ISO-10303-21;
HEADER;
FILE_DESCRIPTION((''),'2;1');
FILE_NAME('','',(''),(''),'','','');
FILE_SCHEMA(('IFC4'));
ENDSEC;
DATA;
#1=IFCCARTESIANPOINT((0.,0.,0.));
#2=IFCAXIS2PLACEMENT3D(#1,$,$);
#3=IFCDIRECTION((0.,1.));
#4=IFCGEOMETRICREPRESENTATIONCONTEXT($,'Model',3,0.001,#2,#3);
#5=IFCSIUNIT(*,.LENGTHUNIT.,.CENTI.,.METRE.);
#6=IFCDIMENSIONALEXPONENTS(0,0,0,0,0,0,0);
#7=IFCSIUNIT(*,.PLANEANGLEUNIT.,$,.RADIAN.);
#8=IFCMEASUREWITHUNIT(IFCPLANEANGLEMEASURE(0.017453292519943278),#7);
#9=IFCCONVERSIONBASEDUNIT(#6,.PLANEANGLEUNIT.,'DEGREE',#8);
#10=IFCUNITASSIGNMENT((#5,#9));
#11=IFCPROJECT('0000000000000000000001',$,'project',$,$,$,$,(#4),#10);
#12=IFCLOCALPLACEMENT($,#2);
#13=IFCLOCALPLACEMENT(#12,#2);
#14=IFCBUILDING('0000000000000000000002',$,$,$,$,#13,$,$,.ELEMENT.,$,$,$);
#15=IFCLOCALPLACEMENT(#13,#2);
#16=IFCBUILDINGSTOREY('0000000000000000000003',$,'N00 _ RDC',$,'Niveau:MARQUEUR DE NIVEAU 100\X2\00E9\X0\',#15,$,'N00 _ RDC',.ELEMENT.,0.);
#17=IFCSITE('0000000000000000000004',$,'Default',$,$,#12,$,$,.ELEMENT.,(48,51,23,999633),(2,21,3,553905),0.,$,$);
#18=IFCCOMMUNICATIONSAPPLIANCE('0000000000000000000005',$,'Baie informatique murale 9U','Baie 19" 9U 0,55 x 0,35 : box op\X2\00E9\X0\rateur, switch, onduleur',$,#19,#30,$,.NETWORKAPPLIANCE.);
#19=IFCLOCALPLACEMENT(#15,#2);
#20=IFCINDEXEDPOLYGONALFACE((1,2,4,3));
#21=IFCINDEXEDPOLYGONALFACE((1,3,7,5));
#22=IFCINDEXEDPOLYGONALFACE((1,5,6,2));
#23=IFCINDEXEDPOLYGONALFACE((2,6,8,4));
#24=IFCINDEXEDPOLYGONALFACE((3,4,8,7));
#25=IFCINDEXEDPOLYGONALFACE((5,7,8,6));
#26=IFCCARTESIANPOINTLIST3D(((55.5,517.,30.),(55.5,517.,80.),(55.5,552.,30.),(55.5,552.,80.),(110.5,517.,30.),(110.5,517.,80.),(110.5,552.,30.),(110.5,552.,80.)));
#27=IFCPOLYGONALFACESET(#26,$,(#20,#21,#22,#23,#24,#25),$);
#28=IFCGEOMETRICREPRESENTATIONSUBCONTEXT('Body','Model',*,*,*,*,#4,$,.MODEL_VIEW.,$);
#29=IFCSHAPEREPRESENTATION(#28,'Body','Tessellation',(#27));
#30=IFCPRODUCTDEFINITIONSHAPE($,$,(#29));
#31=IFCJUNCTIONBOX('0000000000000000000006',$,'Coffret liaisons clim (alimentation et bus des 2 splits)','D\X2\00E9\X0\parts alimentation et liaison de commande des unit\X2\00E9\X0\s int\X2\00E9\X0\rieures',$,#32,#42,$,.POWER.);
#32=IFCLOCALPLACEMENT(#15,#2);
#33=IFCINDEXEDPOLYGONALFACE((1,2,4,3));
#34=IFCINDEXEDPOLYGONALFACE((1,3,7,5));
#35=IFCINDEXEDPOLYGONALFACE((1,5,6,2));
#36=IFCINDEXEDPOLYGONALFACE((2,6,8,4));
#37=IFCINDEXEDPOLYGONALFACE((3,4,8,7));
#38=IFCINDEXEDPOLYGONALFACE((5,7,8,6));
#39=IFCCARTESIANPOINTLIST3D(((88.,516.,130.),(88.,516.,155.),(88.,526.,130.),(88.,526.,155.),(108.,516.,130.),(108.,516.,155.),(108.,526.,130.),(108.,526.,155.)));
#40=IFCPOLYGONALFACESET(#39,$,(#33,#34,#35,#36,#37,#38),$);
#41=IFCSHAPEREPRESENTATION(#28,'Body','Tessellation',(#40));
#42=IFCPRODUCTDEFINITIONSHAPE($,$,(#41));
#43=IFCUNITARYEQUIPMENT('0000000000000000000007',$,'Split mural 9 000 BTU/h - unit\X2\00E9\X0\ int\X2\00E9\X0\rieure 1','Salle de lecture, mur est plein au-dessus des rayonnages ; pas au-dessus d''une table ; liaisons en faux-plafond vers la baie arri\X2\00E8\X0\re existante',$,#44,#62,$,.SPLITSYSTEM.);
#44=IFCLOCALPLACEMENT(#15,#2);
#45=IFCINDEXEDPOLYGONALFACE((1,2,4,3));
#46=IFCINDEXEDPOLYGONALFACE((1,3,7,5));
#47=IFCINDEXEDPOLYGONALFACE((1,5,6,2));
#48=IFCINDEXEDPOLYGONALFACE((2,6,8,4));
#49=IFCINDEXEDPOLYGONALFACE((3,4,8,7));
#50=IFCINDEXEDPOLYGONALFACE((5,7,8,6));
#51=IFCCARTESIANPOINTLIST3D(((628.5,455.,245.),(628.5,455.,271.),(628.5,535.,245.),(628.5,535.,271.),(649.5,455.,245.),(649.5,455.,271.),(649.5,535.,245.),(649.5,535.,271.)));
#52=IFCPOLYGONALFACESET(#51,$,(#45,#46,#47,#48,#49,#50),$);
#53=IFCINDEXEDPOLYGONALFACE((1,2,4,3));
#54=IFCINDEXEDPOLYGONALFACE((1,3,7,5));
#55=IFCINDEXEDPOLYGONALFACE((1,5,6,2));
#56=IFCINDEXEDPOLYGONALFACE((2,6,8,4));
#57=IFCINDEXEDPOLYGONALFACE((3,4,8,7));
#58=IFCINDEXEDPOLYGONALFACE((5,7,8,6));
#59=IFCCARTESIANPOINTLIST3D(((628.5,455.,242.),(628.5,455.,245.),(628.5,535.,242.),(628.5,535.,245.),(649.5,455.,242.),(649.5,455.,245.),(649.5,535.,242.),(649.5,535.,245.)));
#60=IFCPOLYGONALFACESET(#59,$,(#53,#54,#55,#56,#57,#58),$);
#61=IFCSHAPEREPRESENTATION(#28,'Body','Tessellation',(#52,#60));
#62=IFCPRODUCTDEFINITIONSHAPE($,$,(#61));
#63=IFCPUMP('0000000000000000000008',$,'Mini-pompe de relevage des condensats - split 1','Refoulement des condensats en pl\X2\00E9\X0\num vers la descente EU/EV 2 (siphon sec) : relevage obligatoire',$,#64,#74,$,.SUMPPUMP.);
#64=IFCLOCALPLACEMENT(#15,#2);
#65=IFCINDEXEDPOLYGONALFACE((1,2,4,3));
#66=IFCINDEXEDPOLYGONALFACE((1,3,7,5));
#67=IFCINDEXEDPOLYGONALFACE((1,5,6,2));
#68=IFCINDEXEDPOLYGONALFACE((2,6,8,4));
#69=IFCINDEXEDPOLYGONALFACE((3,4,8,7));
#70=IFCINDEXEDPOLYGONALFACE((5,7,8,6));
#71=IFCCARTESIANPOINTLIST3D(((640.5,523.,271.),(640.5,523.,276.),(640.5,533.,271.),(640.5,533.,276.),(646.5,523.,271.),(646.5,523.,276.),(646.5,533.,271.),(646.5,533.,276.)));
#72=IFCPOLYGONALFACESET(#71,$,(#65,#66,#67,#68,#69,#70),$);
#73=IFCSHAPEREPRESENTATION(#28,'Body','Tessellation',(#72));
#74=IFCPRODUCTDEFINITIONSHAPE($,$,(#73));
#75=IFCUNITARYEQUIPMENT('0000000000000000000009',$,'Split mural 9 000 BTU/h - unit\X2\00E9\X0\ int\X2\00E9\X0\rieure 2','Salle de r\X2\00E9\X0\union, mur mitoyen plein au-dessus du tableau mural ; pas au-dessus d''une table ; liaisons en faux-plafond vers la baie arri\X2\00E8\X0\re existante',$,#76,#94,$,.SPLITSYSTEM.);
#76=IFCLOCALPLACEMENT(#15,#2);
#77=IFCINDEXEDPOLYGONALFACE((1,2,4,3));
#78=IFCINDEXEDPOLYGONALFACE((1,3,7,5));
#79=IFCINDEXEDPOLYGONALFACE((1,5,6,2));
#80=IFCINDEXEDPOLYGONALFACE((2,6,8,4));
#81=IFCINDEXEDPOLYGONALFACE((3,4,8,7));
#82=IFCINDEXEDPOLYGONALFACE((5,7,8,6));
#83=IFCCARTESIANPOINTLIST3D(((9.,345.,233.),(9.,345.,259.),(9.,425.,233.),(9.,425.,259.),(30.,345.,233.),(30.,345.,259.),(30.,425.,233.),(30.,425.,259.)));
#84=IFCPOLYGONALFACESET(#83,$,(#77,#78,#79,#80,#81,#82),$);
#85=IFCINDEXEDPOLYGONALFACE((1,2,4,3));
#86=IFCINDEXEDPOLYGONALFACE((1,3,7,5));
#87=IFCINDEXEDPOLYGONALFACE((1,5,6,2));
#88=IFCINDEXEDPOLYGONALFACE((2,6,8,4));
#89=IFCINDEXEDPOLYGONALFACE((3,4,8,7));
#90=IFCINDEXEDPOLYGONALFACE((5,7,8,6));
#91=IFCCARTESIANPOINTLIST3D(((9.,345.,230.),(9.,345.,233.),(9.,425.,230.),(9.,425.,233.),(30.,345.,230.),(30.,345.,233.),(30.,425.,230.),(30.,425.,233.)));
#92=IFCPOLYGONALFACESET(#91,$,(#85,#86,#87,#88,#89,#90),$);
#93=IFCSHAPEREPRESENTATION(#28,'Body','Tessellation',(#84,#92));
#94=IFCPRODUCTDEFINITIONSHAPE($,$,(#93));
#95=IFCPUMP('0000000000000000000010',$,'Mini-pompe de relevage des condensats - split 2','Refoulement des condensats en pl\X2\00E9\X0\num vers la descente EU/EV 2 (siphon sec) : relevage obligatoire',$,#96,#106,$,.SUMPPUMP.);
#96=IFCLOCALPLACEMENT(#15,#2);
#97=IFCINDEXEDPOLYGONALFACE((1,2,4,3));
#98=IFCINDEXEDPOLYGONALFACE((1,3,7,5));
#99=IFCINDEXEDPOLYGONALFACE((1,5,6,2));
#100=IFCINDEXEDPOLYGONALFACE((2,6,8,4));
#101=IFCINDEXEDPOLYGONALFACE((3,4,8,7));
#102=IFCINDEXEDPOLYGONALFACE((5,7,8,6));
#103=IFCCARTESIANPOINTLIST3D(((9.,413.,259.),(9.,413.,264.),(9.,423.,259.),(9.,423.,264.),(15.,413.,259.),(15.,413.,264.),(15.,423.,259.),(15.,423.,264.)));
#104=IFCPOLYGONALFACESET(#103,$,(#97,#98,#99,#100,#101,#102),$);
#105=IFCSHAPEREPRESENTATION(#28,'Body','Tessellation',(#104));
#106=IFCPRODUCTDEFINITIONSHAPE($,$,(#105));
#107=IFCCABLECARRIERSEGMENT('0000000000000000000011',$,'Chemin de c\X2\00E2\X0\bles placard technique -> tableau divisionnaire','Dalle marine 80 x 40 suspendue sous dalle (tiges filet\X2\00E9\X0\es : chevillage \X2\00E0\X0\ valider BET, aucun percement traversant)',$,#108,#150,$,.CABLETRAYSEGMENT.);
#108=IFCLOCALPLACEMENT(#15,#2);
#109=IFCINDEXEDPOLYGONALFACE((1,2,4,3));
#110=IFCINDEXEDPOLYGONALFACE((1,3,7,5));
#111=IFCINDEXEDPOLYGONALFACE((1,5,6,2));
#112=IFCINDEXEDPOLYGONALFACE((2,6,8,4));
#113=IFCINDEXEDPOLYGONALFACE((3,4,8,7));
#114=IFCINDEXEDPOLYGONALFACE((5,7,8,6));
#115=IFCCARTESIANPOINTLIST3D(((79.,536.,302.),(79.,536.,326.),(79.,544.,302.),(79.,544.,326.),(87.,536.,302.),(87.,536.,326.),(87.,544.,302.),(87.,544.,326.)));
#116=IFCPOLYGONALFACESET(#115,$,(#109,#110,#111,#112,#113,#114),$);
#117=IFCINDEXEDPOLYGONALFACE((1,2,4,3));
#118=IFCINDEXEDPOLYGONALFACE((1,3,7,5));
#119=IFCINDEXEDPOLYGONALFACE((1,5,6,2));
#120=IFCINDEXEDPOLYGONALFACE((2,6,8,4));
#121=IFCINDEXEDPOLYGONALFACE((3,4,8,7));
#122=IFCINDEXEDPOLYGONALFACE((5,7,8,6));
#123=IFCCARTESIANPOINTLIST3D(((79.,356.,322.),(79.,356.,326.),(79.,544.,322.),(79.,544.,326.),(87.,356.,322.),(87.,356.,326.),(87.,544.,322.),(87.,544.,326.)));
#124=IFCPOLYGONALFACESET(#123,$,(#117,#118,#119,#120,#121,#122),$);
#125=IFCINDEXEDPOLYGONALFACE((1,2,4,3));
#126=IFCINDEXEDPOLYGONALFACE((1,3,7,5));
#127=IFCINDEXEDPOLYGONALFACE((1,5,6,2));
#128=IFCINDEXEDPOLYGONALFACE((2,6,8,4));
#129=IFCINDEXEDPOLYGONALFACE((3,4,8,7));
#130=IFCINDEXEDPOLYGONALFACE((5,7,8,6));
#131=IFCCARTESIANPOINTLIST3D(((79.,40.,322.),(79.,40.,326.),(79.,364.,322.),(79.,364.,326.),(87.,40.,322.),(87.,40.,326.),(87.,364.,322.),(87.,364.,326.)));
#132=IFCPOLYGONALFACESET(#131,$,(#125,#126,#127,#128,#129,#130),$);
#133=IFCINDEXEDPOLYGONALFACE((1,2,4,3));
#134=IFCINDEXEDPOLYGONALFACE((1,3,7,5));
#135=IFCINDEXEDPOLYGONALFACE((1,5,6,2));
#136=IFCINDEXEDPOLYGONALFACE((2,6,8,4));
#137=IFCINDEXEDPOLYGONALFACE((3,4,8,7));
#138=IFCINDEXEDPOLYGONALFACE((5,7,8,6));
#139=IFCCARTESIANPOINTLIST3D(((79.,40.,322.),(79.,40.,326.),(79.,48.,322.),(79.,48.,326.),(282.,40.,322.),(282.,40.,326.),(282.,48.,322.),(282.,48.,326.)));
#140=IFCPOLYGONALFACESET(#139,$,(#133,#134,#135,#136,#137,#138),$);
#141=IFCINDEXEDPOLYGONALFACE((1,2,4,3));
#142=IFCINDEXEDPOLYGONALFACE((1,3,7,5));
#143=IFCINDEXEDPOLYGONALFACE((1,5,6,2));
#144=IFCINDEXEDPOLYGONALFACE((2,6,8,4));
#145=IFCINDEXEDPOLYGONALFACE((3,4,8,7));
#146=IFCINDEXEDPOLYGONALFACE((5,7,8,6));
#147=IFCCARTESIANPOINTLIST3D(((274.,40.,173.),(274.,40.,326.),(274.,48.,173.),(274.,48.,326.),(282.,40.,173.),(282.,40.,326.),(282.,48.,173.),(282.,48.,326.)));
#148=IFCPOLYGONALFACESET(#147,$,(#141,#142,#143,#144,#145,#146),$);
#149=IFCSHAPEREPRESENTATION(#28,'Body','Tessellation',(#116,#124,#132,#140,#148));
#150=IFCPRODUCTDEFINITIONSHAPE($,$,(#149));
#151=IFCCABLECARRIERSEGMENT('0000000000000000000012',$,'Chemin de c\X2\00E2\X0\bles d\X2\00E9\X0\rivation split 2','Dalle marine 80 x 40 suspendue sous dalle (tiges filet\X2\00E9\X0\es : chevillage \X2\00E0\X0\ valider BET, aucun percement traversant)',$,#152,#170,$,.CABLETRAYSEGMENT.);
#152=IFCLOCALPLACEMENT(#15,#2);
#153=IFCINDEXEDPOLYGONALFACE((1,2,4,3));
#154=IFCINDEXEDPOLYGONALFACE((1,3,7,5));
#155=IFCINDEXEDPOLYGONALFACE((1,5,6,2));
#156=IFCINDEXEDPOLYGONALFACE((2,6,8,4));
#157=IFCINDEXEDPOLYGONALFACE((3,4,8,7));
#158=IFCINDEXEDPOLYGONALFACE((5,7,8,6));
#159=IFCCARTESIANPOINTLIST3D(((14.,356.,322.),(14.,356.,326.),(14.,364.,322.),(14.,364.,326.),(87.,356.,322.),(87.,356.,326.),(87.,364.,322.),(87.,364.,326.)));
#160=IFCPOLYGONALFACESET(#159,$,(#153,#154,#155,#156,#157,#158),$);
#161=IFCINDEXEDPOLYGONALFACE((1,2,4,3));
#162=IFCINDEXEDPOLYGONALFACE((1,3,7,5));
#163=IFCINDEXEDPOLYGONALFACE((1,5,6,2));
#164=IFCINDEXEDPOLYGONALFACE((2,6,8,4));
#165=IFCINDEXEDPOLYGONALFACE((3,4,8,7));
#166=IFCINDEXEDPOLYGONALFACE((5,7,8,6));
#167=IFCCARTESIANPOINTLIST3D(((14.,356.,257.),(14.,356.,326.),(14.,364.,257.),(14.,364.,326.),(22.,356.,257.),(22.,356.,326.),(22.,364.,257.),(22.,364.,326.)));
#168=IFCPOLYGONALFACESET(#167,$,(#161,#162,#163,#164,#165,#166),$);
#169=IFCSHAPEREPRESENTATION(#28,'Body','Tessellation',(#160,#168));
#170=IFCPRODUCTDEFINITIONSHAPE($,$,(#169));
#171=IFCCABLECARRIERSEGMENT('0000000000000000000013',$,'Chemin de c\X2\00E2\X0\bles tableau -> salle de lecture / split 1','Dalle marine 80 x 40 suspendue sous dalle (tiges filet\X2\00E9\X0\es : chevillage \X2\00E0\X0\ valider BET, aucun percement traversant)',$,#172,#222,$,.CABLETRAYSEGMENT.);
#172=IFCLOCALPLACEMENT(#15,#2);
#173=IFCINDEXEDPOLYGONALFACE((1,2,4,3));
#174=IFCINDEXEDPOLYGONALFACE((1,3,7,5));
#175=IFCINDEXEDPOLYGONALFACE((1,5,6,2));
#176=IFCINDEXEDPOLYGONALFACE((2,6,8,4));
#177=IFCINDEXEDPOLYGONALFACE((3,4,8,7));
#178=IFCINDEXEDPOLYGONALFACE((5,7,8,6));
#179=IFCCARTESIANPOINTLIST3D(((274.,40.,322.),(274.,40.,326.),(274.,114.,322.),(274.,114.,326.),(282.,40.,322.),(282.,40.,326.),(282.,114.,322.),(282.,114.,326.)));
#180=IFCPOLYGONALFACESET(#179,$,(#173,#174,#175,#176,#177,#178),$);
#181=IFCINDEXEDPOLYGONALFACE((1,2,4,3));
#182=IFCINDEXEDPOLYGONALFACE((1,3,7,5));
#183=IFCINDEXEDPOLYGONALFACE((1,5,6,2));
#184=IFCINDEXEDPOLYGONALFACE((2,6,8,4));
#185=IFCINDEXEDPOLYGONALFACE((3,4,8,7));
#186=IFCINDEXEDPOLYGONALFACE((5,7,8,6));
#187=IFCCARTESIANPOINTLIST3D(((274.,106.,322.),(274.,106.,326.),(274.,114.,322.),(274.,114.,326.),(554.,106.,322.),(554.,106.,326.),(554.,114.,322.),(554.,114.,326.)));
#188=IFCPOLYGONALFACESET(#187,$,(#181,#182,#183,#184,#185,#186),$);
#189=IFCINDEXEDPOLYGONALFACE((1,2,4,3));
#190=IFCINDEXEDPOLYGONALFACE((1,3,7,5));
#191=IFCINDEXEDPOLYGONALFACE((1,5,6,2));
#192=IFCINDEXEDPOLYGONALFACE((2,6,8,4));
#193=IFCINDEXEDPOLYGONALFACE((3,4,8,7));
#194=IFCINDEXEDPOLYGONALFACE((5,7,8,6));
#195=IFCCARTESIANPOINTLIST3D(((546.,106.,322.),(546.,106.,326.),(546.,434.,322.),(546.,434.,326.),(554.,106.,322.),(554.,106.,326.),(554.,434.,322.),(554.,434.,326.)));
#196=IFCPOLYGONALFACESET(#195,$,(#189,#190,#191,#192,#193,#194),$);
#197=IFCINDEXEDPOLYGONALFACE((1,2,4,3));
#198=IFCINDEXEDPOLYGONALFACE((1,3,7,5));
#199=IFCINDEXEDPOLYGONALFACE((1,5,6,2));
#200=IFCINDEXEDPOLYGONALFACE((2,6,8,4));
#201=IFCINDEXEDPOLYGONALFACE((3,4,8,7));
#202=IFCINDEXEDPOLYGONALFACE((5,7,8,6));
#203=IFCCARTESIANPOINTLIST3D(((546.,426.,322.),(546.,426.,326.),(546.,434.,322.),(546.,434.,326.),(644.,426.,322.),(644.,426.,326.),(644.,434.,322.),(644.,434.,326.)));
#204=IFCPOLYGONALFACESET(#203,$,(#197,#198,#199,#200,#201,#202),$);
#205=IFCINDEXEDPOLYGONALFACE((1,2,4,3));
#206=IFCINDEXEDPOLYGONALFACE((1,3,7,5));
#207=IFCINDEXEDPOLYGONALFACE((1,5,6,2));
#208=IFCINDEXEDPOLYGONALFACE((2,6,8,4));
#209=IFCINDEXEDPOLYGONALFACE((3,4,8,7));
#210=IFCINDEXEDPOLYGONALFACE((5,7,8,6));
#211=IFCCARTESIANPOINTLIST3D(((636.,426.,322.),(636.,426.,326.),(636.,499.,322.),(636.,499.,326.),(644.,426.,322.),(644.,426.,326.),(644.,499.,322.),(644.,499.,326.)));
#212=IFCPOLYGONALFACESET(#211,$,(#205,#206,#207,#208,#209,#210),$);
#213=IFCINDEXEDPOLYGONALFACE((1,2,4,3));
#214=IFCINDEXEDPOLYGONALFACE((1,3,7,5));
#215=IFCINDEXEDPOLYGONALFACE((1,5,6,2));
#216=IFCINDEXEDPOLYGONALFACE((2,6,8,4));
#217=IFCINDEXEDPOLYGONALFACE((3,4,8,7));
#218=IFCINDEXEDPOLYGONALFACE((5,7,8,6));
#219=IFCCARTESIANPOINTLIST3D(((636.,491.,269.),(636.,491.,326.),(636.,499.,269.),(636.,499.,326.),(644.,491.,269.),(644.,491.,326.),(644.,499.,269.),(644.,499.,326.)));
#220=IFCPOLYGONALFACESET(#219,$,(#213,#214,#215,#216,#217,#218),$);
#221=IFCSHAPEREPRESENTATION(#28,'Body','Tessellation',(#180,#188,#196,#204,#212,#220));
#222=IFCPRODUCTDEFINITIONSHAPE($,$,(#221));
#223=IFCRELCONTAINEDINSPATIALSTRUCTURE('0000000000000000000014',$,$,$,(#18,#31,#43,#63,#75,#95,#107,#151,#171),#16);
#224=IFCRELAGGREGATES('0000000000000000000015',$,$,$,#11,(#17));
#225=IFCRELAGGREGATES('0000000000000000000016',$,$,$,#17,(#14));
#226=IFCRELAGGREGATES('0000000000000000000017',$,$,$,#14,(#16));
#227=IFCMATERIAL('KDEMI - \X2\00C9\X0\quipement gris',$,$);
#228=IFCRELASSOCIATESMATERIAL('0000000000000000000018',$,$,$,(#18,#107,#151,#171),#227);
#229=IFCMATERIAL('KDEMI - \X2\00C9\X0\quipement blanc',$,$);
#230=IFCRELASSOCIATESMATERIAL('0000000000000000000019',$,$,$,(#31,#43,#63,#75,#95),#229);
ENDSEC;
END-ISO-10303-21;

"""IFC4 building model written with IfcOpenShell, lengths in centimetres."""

from ifc_helpers import new_model, entity, si_unit, converted_unit, direction, frame, frame_2d, origin, origin_with_axes, place, context, subcontext, project, spatial, rectangle, extrude, material, element, save


model = new_model("IFC4")

# Units and contexts
model_context = context("Model", 3, precision=0.001, world=origin(), true_north=direction((0.0, 1.0)))
body_context = subcontext(model_context, "Body", "Model", "MODEL_VIEW")
ifc_project = project(units=[si_unit("LENGTHUNIT", "METRE", prefix="CENTI"), converted_unit("PLANEANGLEUNIT", "DEGREE", entity("IfcPlaneAngleMeasure", 0.017453292519943278), si_unit("PLANEANGLEUNIT", "RADIAN"), dimensions=[0, 0, 0, 0, 0, 0, 0])], contexts=[model_context])

# Site, building, storey
site_placement = place(None, origin())
site = spatial("IfcSite", under=ifc_project, at=site_placement, Name="Default", CompositionType="ELEMENT", RefLatitude=(48, 51, 23, 999633), RefLongitude=(2, 21, 3, 553905), RefElevation=0.0)
building_placement = place(site_placement, origin())
building = spatial("IfcBuilding", under=site, at=building_placement, CompositionType="ELEMENT")
storey_placement = place(building_placement, origin())
storey = spatial("IfcBuildingStorey", under=building, at=storey_placement, Name="N00 _ RDC", ObjectType="Niveau:MARQUEUR DE NIVEAU 100é", LongName="N00 _ RDC", CompositionType="ELEMENT", Elevation=0.0)

# Shared definitions
ifc_material_1 = material(Name="KDEMI - Équipement blanc")

# Communications appliance
ifc_material_2 = material(Name="KDEMI - Équipement gris")
communications_appliance_placement = place(storey_placement, origin_with_axes())
element("IfcCommunicationsAppliance", 1, at=communications_appliance_placement, inside=storey, material=ifc_material_2, Name="Baie informatique murale 9U", Description="Baie 19\" 9U 0,55 x 0,35 : box opérateur, switch, onduleur", PredefinedType="NETWORKAPPLIANCE", context=body_context, shape_type="SweptSolid", body=[
    extrude(rectangle(XDim=55.0, YDim=35.0, at=frame_2d((83.0, 534.5))), frame((0.0, 0.0, 30.0)), (0.0, 0.0, 1.0), 50.0),
])

# Junction box
junction_box_placement = place(storey_placement, origin_with_axes())
element("IfcJunctionBox", 2, at=junction_box_placement, inside=storey, material=ifc_material_1, Name="Coffret liaisons clim (alimentation et bus des 2 splits)", Description="Départs alimentation et liaison de commande des unités intérieures", PredefinedType="POWER", context=body_context, shape_type="SweptSolid", body=[
    extrude(rectangle(XDim=20.0, YDim=10.0, at=frame_2d((98.0, 521.0))), frame((0.0, 0.0, 130.0)), (0.0, 0.0, 1.0), 25.0),
])

# Unitary equipment
unitary_equipment_1_placement = place(storey_placement, origin_with_axes())
element("IfcUnitaryEquipment", 3, at=unitary_equipment_1_placement, inside=storey, material=ifc_material_1, Name="Split mural 9 000 BTU/h - unité intérieure 1", Description="Salle de lecture, mur est plein au-dessus des rayonnages ; pas au-dessus d'une table ; liaisons en faux-plafond vers la baie arrière existante", PredefinedType="SPLITSYSTEM", context=body_context, shape_type="SweptSolid", body=[
    extrude(rectangle(XDim=21.0, YDim=80.0, at=frame_2d((639.0, 495.0))), frame((0.0, 0.0, 245.0)), (0.0, 0.0, 1.0), 26.0),
    extrude(rectangle(XDim=21.0, YDim=80.0, at=frame_2d((639.0, 495.0))), frame((0.0, 0.0, 242.0)), (0.0, 0.0, 1.0), 3.0),
])

# Pump
pump_1_placement = place(storey_placement, origin_with_axes())
element("IfcPump", 4, at=pump_1_placement, inside=storey, material=ifc_material_1, Name="Mini-pompe de relevage des condensats - split 1", Description="Refoulement des condensats en plénum vers la descente EU/EV 2 (siphon sec) : relevage obligatoire", PredefinedType="SUMPPUMP", context=body_context, shape_type="SweptSolid", body=[
    extrude(rectangle(XDim=6.0, YDim=10.0, at=frame_2d((643.5, 528.0))), frame((0.0, 0.0, 271.0)), (0.0, 0.0, 1.0), 5.0),
])

# Unitary equipment
unitary_equipment_2_placement = place(storey_placement, origin_with_axes())
element("IfcUnitaryEquipment", 5, at=unitary_equipment_2_placement, inside=storey, material=ifc_material_1, Name="Split mural 9 000 BTU/h - unité intérieure 2", Description="Salle de réunion, mur mitoyen plein au-dessus du tableau mural ; pas au-dessus d'une table ; liaisons en faux-plafond vers la baie arrière existante", PredefinedType="SPLITSYSTEM", context=body_context, shape_type="SweptSolid", body=[
    extrude(rectangle(XDim=21.0, YDim=80.0, at=frame_2d((19.5, 385.0))), frame((0.0, 0.0, 233.0)), (0.0, 0.0, 1.0), 26.0),
    extrude(rectangle(XDim=21.0, YDim=80.0, at=frame_2d((19.5, 385.0))), frame((0.0, 0.0, 230.0)), (0.0, 0.0, 1.0), 3.0),
])

# Pump
pump_2_placement = place(storey_placement, origin_with_axes())
element("IfcPump", 6, at=pump_2_placement, inside=storey, material=ifc_material_1, Name="Mini-pompe de relevage des condensats - split 2", Description="Refoulement des condensats en plénum vers la descente EU/EV 2 (siphon sec) : relevage obligatoire", PredefinedType="SUMPPUMP", context=body_context, shape_type="SweptSolid", body=[
    extrude(rectangle(XDim=6.0, YDim=10.0, at=frame_2d((12.0, 418.0))), frame((0.0, 0.0, 259.0)), (0.0, 0.0, 1.0), 5.0),
])

# Cable carrier segments
cable_carrier_segment_1_placement = place(storey_placement, origin_with_axes())
element("IfcCableCarrierSegment", 7, at=cable_carrier_segment_1_placement, inside=storey, material=ifc_material_2, Name="Chemin de câbles placard technique -> tableau divisionnaire", Description="Dalle marine 80 x 40 suspendue sous dalle (tiges filetées : chevillage à valider BET, aucun percement traversant)", PredefinedType="CABLETRAYSEGMENT", context=body_context, shape_type="SweptSolid", body=[
    extrude(rectangle(XDim=8.0, YDim=8.0, at=frame_2d((83.0, 540.0))), frame((0.0, 0.0, 302.0)), (0.0, 0.0, 1.0), 24.0),
    extrude(rectangle(XDim=8.0, YDim=188.0, at=frame_2d((83.0, 450.0))), frame((0.0, 0.0, 322.0)), (0.0, 0.0, 1.0), 4.0),
    extrude(rectangle(XDim=8.0, YDim=324.0, at=frame_2d((83.0, 202.0))), frame((0.0, 0.0, 322.0)), (0.0, 0.0, 1.0), 4.0),
    extrude(rectangle(XDim=203.0, YDim=8.0, at=frame_2d((180.5, 44.0))), frame((0.0, 0.0, 322.0)), (0.0, 0.0, 1.0), 4.0),
    extrude(rectangle(XDim=8.0, YDim=8.0, at=frame_2d((278.0, 44.0))), frame((0.0, 0.0, 173.0)), (0.0, 0.0, 1.0), 153.0),
])
cable_carrier_segment_2_placement = place(storey_placement, origin_with_axes())
element("IfcCableCarrierSegment", 8, at=cable_carrier_segment_2_placement, inside=storey, material=ifc_material_2, Name="Chemin de câbles dérivation split 2", Description="Dalle marine 80 x 40 suspendue sous dalle (tiges filetées : chevillage à valider BET, aucun percement traversant)", PredefinedType="CABLETRAYSEGMENT", context=body_context, shape_type="SweptSolid", body=[
    extrude(rectangle(XDim=73.0, YDim=8.0, at=frame_2d((50.5, 360.0))), frame((0.0, 0.0, 322.0)), (0.0, 0.0, 1.0), 4.0),
    extrude(rectangle(XDim=8.0, YDim=8.0, at=frame_2d((18.0, 360.0))), frame((0.0, 0.0, 257.0)), (0.0, 0.0, 1.0), 69.0),
])
cable_carrier_segment_3_placement = place(storey_placement, origin_with_axes())
element("IfcCableCarrierSegment", 9, at=cable_carrier_segment_3_placement, inside=storey, material=ifc_material_2, Name="Chemin de câbles tableau -> salle de lecture / split 1", Description="Dalle marine 80 x 40 suspendue sous dalle (tiges filetées : chevillage à valider BET, aucun percement traversant)", PredefinedType="CABLETRAYSEGMENT", context=body_context, shape_type="SweptSolid", body=[
    extrude(rectangle(XDim=8.0, YDim=74.0, at=frame_2d((278.0, 77.0))), frame((0.0, 0.0, 322.0)), (0.0, 0.0, 1.0), 4.0),
    extrude(rectangle(XDim=280.0, YDim=8.0, at=frame_2d((414.0, 110.0))), frame((0.0, 0.0, 322.0)), (0.0, 0.0, 1.0), 4.0),
    extrude(rectangle(XDim=8.0, YDim=328.0, at=frame_2d((550.0, 270.0))), frame((0.0, 0.0, 322.0)), (0.0, 0.0, 1.0), 4.0),
    extrude(rectangle(XDim=98.0, YDim=8.0, at=frame_2d((595.0, 430.0))), frame((0.0, 0.0, 322.0)), (0.0, 0.0, 1.0), 4.0),
    extrude(rectangle(XDim=8.0, YDim=73.0, at=frame_2d((640.0, 462.5))), frame((0.0, 0.0, 322.0)), (0.0, 0.0, 1.0), 4.0),
    extrude(rectangle(XDim=8.0, YDim=8.0, at=frame_2d((640.0, 495.0))), frame((0.0, 0.0, 269.0)), (0.0, 0.0, 1.0), 57.0),
])

save(model, "model.ifc")
